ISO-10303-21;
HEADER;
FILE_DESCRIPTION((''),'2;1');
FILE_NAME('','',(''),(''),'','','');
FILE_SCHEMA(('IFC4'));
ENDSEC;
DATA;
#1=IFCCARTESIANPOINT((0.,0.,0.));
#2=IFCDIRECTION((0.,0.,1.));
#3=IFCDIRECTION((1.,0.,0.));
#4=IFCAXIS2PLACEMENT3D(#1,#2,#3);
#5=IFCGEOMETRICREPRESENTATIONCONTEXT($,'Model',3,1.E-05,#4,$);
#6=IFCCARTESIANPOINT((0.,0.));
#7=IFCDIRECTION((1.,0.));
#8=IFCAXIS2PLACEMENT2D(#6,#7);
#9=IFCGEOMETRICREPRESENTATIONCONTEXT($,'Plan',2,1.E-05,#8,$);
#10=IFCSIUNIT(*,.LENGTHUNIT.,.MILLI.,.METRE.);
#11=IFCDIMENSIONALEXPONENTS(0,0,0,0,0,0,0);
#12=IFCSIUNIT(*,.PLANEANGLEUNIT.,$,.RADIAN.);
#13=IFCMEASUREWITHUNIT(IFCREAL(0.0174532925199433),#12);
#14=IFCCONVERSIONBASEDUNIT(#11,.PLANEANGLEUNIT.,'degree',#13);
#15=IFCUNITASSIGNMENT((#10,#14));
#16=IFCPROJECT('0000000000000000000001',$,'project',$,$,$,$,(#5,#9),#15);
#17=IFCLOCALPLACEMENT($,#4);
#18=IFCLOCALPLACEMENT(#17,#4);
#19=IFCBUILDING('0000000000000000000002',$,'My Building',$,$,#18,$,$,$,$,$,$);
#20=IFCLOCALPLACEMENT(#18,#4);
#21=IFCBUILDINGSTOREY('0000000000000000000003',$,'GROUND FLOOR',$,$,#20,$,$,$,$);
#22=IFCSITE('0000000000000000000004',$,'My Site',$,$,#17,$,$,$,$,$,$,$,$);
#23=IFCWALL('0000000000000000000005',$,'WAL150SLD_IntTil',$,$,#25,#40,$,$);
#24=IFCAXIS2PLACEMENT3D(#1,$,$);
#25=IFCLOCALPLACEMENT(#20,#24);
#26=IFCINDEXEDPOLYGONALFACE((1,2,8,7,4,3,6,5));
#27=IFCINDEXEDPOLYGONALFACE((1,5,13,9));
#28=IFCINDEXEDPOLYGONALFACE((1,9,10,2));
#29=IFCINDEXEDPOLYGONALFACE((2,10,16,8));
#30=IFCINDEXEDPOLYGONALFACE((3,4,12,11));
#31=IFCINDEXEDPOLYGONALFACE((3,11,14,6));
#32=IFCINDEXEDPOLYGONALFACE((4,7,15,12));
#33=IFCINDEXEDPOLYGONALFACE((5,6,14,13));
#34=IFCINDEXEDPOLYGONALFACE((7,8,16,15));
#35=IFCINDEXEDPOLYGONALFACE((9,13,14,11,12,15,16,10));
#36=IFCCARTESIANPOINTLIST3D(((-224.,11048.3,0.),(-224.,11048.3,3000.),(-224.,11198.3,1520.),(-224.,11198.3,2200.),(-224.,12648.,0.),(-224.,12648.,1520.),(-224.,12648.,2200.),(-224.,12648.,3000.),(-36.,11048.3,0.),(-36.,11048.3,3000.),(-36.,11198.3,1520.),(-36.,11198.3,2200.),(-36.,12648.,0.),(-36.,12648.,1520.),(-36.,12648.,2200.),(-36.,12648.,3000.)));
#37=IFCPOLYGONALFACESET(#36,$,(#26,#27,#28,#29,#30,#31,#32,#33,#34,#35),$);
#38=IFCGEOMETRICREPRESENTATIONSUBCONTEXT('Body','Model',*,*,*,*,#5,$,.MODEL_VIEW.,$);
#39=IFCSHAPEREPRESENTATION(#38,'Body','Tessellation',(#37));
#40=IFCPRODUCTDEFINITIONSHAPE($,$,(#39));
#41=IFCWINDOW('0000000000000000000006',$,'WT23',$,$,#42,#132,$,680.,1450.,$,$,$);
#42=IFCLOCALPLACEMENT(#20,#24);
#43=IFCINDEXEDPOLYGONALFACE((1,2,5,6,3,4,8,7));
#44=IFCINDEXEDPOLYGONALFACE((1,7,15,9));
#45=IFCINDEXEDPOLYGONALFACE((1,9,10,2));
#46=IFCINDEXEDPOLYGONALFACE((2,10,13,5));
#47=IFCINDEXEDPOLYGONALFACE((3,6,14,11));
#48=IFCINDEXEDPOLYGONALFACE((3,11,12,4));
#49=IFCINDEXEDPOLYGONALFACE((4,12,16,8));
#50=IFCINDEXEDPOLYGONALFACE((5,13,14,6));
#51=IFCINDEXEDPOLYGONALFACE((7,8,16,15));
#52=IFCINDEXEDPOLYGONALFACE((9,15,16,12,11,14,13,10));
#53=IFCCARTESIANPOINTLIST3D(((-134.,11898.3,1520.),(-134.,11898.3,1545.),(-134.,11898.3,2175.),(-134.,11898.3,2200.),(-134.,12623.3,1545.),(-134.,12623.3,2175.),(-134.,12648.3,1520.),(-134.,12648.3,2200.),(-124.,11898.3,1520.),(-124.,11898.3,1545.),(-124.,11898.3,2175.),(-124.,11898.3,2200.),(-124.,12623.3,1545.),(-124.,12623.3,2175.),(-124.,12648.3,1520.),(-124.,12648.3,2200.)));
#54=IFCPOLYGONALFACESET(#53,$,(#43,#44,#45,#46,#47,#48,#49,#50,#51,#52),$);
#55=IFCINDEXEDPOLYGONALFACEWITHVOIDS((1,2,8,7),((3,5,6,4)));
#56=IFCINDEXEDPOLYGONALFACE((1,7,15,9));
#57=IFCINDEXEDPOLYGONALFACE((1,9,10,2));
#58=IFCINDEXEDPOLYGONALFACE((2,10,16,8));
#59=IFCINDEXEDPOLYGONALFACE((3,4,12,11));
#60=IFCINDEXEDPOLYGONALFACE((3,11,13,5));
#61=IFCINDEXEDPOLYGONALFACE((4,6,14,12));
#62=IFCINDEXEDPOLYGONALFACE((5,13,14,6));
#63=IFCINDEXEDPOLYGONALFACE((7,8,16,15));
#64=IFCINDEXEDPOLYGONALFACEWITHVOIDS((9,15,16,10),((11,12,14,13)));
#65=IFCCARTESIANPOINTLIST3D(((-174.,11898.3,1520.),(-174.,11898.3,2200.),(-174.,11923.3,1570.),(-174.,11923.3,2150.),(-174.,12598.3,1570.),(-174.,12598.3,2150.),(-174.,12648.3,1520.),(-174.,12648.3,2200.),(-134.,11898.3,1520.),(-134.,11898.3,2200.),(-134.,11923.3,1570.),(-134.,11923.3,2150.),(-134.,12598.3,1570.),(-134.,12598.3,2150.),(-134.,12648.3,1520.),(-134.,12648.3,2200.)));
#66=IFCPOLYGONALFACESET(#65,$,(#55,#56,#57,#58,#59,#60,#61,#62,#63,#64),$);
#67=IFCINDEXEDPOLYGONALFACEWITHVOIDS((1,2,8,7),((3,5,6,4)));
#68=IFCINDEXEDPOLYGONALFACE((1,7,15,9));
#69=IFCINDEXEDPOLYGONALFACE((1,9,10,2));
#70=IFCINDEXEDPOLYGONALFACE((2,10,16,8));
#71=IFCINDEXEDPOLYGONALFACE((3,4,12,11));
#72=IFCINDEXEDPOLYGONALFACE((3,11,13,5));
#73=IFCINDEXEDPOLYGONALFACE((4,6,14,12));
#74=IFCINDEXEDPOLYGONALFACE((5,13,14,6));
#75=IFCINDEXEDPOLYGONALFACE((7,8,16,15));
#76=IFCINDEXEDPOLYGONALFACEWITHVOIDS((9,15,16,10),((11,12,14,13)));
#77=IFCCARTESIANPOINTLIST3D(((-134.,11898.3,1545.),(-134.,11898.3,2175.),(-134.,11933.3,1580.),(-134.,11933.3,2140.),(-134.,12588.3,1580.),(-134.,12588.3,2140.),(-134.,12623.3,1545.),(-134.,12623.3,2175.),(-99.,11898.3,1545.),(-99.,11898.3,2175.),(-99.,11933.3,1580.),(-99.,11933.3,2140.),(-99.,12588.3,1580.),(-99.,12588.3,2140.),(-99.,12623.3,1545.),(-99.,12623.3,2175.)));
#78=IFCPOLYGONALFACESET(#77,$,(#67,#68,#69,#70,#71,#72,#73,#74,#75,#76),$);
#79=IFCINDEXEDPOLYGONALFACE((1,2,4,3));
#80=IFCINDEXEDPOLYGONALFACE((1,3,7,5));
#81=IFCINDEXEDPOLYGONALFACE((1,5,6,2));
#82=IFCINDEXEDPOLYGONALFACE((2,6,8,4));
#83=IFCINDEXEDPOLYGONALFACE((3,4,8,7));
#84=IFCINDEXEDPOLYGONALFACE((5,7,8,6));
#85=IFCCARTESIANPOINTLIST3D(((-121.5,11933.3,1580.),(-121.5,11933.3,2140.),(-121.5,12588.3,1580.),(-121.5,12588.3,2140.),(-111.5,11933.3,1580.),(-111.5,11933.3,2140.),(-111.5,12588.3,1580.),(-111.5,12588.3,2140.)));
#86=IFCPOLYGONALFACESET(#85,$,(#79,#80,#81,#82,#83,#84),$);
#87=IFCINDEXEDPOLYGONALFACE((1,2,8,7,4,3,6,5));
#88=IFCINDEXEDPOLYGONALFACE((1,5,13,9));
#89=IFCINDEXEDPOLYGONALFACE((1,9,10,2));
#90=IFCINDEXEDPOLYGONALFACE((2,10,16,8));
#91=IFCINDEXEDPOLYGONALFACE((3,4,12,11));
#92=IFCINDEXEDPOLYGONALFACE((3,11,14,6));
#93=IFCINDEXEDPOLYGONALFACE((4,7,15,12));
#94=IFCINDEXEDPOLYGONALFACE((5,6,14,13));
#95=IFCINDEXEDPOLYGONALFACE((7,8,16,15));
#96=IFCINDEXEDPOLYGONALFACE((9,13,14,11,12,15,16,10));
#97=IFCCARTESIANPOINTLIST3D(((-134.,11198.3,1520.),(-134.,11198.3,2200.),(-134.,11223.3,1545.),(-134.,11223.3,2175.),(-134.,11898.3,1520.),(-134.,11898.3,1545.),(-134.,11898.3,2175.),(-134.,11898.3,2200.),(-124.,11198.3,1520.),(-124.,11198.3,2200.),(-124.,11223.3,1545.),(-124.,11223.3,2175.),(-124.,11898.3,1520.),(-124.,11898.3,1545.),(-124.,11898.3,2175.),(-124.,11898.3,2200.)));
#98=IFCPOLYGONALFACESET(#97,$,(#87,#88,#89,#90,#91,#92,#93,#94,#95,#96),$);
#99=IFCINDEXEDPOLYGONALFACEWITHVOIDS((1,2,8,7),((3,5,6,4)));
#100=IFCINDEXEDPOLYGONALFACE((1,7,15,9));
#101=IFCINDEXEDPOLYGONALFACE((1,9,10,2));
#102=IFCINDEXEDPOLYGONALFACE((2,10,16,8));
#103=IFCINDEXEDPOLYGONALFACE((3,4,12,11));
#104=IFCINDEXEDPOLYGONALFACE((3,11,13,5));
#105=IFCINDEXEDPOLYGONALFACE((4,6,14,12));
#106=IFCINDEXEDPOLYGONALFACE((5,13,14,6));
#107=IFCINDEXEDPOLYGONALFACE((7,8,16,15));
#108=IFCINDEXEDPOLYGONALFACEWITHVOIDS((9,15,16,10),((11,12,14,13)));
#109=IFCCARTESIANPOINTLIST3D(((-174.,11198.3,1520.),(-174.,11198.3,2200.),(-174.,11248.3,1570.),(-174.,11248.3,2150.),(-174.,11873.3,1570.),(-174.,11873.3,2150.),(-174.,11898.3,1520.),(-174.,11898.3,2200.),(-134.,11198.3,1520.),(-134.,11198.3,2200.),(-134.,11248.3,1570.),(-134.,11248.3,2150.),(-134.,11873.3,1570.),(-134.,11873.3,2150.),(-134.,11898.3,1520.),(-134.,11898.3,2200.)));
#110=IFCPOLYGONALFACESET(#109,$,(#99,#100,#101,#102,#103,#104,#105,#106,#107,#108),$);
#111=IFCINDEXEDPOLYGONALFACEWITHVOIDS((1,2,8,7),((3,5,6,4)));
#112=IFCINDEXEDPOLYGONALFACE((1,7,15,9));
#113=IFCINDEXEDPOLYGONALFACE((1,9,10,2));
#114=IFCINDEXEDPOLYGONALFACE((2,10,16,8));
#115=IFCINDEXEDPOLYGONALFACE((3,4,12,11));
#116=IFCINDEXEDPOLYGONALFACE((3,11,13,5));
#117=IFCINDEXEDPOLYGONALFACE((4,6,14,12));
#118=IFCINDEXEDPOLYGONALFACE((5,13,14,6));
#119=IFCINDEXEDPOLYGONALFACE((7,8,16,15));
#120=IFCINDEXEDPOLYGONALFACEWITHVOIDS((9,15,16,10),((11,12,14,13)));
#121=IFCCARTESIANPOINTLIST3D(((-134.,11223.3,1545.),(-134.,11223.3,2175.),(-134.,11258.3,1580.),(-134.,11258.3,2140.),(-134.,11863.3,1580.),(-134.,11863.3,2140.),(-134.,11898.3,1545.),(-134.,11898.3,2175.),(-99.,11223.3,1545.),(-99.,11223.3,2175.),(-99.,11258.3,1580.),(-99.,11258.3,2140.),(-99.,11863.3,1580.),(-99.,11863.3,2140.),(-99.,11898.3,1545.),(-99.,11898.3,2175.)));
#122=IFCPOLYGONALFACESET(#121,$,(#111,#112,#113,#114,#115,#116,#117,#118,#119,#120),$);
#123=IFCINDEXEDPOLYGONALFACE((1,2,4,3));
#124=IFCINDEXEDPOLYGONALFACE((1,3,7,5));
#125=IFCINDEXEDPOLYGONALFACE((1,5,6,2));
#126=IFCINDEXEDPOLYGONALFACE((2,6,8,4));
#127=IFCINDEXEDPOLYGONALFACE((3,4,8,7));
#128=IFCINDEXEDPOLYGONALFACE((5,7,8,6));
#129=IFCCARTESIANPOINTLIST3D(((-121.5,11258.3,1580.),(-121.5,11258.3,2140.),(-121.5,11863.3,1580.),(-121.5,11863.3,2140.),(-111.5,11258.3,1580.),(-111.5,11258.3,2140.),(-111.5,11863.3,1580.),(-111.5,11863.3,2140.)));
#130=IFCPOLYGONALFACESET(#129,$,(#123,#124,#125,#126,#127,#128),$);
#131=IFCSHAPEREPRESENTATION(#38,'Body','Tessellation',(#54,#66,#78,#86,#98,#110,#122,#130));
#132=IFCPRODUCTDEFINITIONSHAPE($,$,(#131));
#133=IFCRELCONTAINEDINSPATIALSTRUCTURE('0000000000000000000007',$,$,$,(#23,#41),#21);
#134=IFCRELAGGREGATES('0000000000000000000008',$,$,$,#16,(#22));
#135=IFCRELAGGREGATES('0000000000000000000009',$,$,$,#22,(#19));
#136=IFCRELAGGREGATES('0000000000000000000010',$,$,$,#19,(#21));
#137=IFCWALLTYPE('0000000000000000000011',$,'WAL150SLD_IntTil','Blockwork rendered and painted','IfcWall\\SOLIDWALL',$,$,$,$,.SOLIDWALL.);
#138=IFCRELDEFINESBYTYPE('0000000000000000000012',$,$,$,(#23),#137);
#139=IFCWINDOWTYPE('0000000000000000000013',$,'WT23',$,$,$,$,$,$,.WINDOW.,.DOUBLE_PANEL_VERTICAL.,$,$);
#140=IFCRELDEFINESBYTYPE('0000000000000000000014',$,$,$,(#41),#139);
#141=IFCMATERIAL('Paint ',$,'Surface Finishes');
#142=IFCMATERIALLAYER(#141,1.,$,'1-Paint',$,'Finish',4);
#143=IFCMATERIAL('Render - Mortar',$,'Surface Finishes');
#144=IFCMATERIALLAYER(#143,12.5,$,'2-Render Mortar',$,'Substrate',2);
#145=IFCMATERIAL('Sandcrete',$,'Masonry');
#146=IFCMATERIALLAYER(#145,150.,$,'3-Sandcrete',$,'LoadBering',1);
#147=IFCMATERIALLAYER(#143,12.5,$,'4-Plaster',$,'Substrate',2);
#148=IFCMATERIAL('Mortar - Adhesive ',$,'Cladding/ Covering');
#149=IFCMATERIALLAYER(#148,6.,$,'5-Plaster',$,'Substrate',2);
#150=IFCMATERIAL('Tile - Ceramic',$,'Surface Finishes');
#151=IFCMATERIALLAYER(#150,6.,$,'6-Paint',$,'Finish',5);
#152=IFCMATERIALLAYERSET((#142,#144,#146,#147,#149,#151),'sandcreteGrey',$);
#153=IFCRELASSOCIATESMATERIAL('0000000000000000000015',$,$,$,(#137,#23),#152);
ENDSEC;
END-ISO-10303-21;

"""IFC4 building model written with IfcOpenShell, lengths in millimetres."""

from ifc_helpers import new_model, entity, si_unit, converted_unit, frame, origin_with_axes, origin_2d_with_axis, place, context, subcontext, project, spatial, line, indexed_curve, outline, extrude, shape, source, transform, mapped, material, layer, layer_set, layer_usage, type_object, type_shapes, element, fill, save


model = new_model("IFC4")

# Units and contexts
model_context = context("Model", 3, precision=1e-05, world=origin_with_axes())
plan_context = context("Plan", 2, precision=1e-05, world=origin_2d_with_axis())
body_context_1 = subcontext(model_context, "Body", "Model", "MODEL_VIEW")
body_context_2 = subcontext(plan_context, "Body", "Plan", "PLAN_VIEW")
ifc_project = project(units=[si_unit("LENGTHUNIT", "METRE", prefix="MILLI"), converted_unit("PLANEANGLEUNIT", "degree", entity("IfcReal", 0.0174532925199433), si_unit("PLANEANGLEUNIT", "RADIAN"), dimensions=[0, 0, 0, 0, 0, 0, 0])], contexts=[model_context, plan_context])

# Site, building, storey
site_placement = place(None, origin_with_axes())
site = spatial("IfcSite", under=ifc_project, at=site_placement, Name="My Site")
building_placement = place(site_placement, origin_with_axes())
building = spatial("IfcBuilding", under=site, at=building_placement, Name="My Building")
storey_placement = place(building_placement, origin_with_axes())
storey = spatial("IfcBuildingStorey", under=building, at=storey_placement, Name="GROUND FLOOR")

# Shared definitions
ifc_material_1 = material(Name="Paint ", Category="Surface Finishes")
ifc_material_2 = material(Name="Render - Mortar", Category="Surface Finishes")
ifc_material_3 = material(Name="Sandcrete", Category="Masonry")

# Shared definitions
ifc_material_4 = material(Name="Mortar - Adhesive ", Category="Cladding/ Covering")
ifc_material_5 = material(Name="Tile - Ceramic", Category="Surface Finishes")

# Shared definitions
ifc_layer_1 = layer(ifc_material_1, 1.0, Name="1-Paint", Category="Finish", Priority=4)
ifc_layer_2 = layer(ifc_material_2, 12.5, Name="2-Render Mortar", Category="Substrate", Priority=2)
ifc_layer_3 = layer(ifc_material_3, 150.0, Name="3-Sandcrete", Category="LoadBering", Priority=1)
ifc_layer_4 = layer(ifc_material_2, 12.5, Name="4-Plaster", Category="Substrate", Priority=2)
ifc_layer_5 = layer(ifc_material_4, 6.0, Name="5-Plaster", Category="Substrate", Priority=2)
ifc_layer_6 = layer(ifc_material_5, 6.0, Name="6-Paint", Category="Finish", Priority=5)
ifc_layer_set_1 = layer_set([ifc_layer_1, ifc_layer_2, ifc_layer_3, ifc_layer_4, ifc_layer_5, ifc_layer_6], Name="sandcreteGrey")
wall_type_1 = type_object("IfcWallType", Name="WAL150SLD_IntTil", Description="Blockwork rendered and painted", ApplicableOccurrence="IfcWall\\SOLIDWALL", PredefinedType="SOLIDWALL", material=ifc_layer_set_1)

# Wall, opening, window
ifc_layer_usage_1 = layer_usage(ifc_layer_set_1, "AXIS2", "POSITIVE", 0.0)
wall_1_placement = place(storey_placement, frame((-224.0, 12648.0, 0.0), z_axis=(0.0, 0.0, 1.0), x_axis=(0.0, -1.0, 0.0)))
wall_1 = element("IfcWall", 1, at=wall_1_placement, inside=storey, type_object=wall_type_1, material=ifc_layer_usage_1, Name="WAL150SLD_IntTil", context=body_context_1, shape_type="SweptSolid", body=[
    extrude(outline(indexed_curve([(0.0, 0.0), (0.0, 188.0), (1599.7, 188.0), (1599.7, 0.0), (0.0, 0.0)], self_intersect=False)), origin_with_axes(), (0.0, 0.0, 1.0), 3000.0),
])
shared_shape_1 = source(origin_with_axes(), body_context_1, "Body", "SweptSolid", [
    extrude(outline(indexed_curve([(0.0, 0.0), (1450.0, 0.0), (1450.0, 680.0), (0.0, 680.0)], segments=[line(1, 2, 3, 4, 1)])), frame((0.0, -600.0, 0.0), z_axis=(0.0, -1.0, 0.0), x_axis=(1.0, 0.0, 0.0)), (0.0, 0.0, -1.0), 1200.0),
])
opening_1_placement = place(wall_1_placement, frame((-0.3, 0.0, 1520.0), z_axis=(0.0, 0.0, 1.0), x_axis=(1.0, 0.0, 0.0)))
opening_1 = element("IfcOpeningElement", 2, at=opening_1_placement, cuts=wall_1, PredefinedType="OPENING", context=body_context_1, shape_type="MappedRepresentation", body=[
    mapped(shared_shape_1, transform((0.0, 0.0, 0.0), x_axis=(1.0, 0.0, 0.0), y_axis=(0.0, 1.0, 0.0), z_axis=(0.0, 0.0, 1.0), scale=1.0)),
])
window_type_1 = type_object("IfcWindowType", Name="WT23", PartitioningType="DOUBLE_PANEL_VERTICAL", PredefinedType="WINDOW")
shared_shape_2 = source(origin_with_axes(), body_context_1, "Body", "SweptSolid", [
    extrude(outline(indexed_curve([(750.0, 0.0), (0.0, 0.0), (0.0, 680.0), (750.0, 680.0), (750.0, 655.0), (25.0, 655.0), (25.0, 25.0), (750.0, 25.0)], segments=[line(1, 2, 3, 4, 5, 6, 7, 8, 1)])), frame((0.0, 90.0, 0.0), z_axis=(0.0, -1.0, 0.0), x_axis=(1.0, 0.0, 0.0)), (0.0, 0.0, -1.0), 10.0),
    extrude(outline(indexed_curve([(0.0, 0.0), (750.0, 0.0), (750.0, 680.0), (0.0, 680.0)], segments=[line(1, 2, 3, 4, 1)]), holes=[indexed_curve([(50.0, 50.0), (725.0, 50.0), (725.0, 630.0), (50.0, 630.0)], segments=[line(1, 2, 3, 4, 1)])]), frame((0.0, 50.0, 0.0), z_axis=(0.0, -1.0, 0.0), x_axis=(1.0, 0.0, 0.0)), (0.0, 0.0, -1.0), 40.0),
    extrude(outline(indexed_curve([(0.0, 0.0), (725.0, 0.0), (725.0, 630.0), (0.0, 630.0)], segments=[line(1, 2, 3, 4, 1)]), holes=[indexed_curve([(35.0, 35.0), (690.0, 35.0), (690.0, 595.0), (35.0, 595.0)], segments=[line(1, 2, 3, 4, 1)])]), frame((25.0, 90.0, 25.0), z_axis=(0.0, -1.0, 0.0), x_axis=(1.0, 0.0, 0.0)), (0.0, 0.0, -1.0), 35.0),
    extrude(outline(indexed_curve([(35.0, 35.0), (690.0, 35.0), (690.0, 595.0), (35.0, 595.0)], segments=[line(1, 2, 3, 4, 1)])), frame((25.0, 102.5, 25.0), z_axis=(0.0, -1.0, 0.0), x_axis=(1.0, 0.0, 0.0)), (0.0, 0.0, -1.0), 10.0),
    extrude(outline(indexed_curve([(0.0, 680.0), (700.0, 680.0), (700.0, 0.0), (0.0, 0.0), (0.0, 25.0), (675.0, 25.0), (675.0, 655.0), (0.0, 655.0)], segments=[line(1, 2, 3, 4, 5, 6, 7, 8, 1)])), frame((750.0, 90.0, 0.0), z_axis=(0.0, -1.0, 0.0), x_axis=(1.0, 0.0, 0.0)), (0.0, 0.0, -1.0), 10.0),
    extrude(outline(indexed_curve([(0.0, 0.0), (700.0, 0.0), (700.0, 680.0), (0.0, 680.0)], segments=[line(1, 2, 3, 4, 1)]), holes=[indexed_curve([(25.0, 50.0), (650.0, 50.0), (650.0, 630.0), (25.0, 630.0)], segments=[line(1, 2, 3, 4, 1)])]), frame((750.0, 50.0, 0.0), z_axis=(0.0, -1.0, 0.0), x_axis=(1.0, 0.0, 0.0)), (0.0, 0.0, -1.0), 40.0),
    extrude(outline(indexed_curve([(0.0, 0.0), (675.0, 0.0), (675.0, 630.0), (0.0, 630.0)], segments=[line(1, 2, 3, 4, 1)]), holes=[indexed_curve([(35.0, 35.0), (640.0, 35.0), (640.0, 595.0), (35.0, 595.0)], segments=[line(1, 2, 3, 4, 1)])]), frame((750.0, 90.0, 25.0), z_axis=(0.0, -1.0, 0.0), x_axis=(1.0, 0.0, 0.0)), (0.0, 0.0, -1.0), 35.0),
    extrude(outline(indexed_curve([(35.0, 35.0), (640.0, 35.0), (640.0, 595.0), (35.0, 595.0)], segments=[line(1, 2, 3, 4, 1)])), frame((750.0, 102.5, 25.0), z_axis=(0.0, -1.0, 0.0), x_axis=(1.0, 0.0, 0.0)), (0.0, 0.0, -1.0), 10.0),
])
shared_shape_3 = source(origin_with_axes(), body_context_2, "Body", "Curve2D", [
    entity("IfcIndexedPolyCurve", entity("IfcCartesianPointList2D", [[50.0, 50.0], [725.0, 50.0]])),
    entity("IfcIndexedPolyCurve", entity("IfcCartesianPointList2D", [[0.0, 100.0], [25.0, 100.0], [25.0, 90.0], [50.0, 90.0], [50.0, 50.0], [0.0, 50.0]]), [entity("IfcLineIndex", [1, 2, 3, 4, 5, 6, 1])]),
    entity("IfcIndexedPolyCurve", entity("IfcCartesianPointList2D", [[750.0, 100.0], [750.0, 100.0], [750.0, 90.0], [725.0, 90.0], [725.0, 50.0], [750.0, 50.0]])),
    entity("IfcIndexedPolyCurve", entity("IfcCartesianPointList2D", [[25.0, 90.0], [60.0, 90.0], [60.0, 125.0], [25.0, 125.0]]), [entity("IfcLineIndex", [1, 2, 3, 4, 1])]),
    entity("IfcIndexedPolyCurve", entity("IfcCartesianPointList2D", [[750.0, 90.0], [715.0, 90.0], [715.0, 125.0], [750.0, 125.0]]), [entity("IfcLineIndex", [1, 2, 3, 4, 1])]),
    entity("IfcIndexedPolyCurve", entity("IfcCartesianPointList2D", [[60.0, 90.0], [715.0, 90.0]])),
    entity("IfcIndexedPolyCurve", entity("IfcCartesianPointList2D", [[60.0, 125.0], [715.0, 125.0]])),
    entity("IfcIndexedPolyCurve", entity("IfcCartesianPointList2D", [[60.0, 107.5], [715.0, 107.5]])),
    entity("IfcIndexedPolyCurve", entity("IfcCartesianPointList2D", [[775.0, 50.0], [1400.0, 50.0]])),
    entity("IfcIndexedPolyCurve", entity("IfcCartesianPointList2D", [[750.0, 100.0], [750.0, 100.0], [750.0, 90.0], [775.0, 90.0], [775.0, 50.0], [750.0, 50.0]])),
    entity("IfcIndexedPolyCurve", entity("IfcCartesianPointList2D", [[1450.0, 100.0], [1425.0, 100.0], [1425.0, 90.0], [1400.0, 90.0], [1400.0, 50.0], [1450.0, 50.0]]), [entity("IfcLineIndex", [1, 2, 3, 4, 5, 6, 1])]),
    entity("IfcIndexedPolyCurve", entity("IfcCartesianPointList2D", [[750.0, 90.0], [785.0, 90.0], [785.0, 125.0], [750.0, 125.0]]), [entity("IfcLineIndex", [1, 2, 3, 4, 1])]),
    entity("IfcIndexedPolyCurve", entity("IfcCartesianPointList2D", [[1425.0, 90.0], [1390.0, 90.0], [1390.0, 125.0], [1425.0, 125.0]]), [entity("IfcLineIndex", [1, 2, 3, 4, 1])]),
    entity("IfcIndexedPolyCurve", entity("IfcCartesianPointList2D", [[785.0, 90.0], [1390.0, 90.0]])),
    entity("IfcIndexedPolyCurve", entity("IfcCartesianPointList2D", [[785.0, 125.0], [1390.0, 125.0]])),
    entity("IfcIndexedPolyCurve", entity("IfcCartesianPointList2D", [[785.0, 107.5], [1390.0, 107.5]])),
])
type_shapes(window_type_1, [shared_shape_2, shared_shape_3])
window_1_placement = place(opening_1_placement, frame((0.0, 0.0, 0.0), z_axis=(0.0, 0.0, 1.0), x_axis=(1.0, 0.0, 0.0)))
window_1 = element("IfcWindow", 3, at=window_1_placement, inside=storey, type_object=window_type_1, Name="WT23", OverallHeight=680.0, OverallWidth=1450.0, shapes=[
    shape(body_context_1, "Body", "MappedRepresentation", [mapped(shared_shape_2, transform((0.0, 0.0, 0.0), x_axis=(1.0, 0.0, 0.0), y_axis=(0.0, 1.0, 0.0), z_axis=(0.0, 0.0, 1.0), scale=1.0))]),
    shape(body_context_2, "Body", "MappedRepresentation", [mapped(shared_shape_3, transform((0.0, 0.0, 0.0), x_axis=(1.0, 0.0, 0.0), y_axis=(0.0, 1.0, 0.0), z_axis=(0.0, 0.0, 1.0), scale=1.0))]),
])
fill(opening_1, window_1)

save(model, "model.ifc")
